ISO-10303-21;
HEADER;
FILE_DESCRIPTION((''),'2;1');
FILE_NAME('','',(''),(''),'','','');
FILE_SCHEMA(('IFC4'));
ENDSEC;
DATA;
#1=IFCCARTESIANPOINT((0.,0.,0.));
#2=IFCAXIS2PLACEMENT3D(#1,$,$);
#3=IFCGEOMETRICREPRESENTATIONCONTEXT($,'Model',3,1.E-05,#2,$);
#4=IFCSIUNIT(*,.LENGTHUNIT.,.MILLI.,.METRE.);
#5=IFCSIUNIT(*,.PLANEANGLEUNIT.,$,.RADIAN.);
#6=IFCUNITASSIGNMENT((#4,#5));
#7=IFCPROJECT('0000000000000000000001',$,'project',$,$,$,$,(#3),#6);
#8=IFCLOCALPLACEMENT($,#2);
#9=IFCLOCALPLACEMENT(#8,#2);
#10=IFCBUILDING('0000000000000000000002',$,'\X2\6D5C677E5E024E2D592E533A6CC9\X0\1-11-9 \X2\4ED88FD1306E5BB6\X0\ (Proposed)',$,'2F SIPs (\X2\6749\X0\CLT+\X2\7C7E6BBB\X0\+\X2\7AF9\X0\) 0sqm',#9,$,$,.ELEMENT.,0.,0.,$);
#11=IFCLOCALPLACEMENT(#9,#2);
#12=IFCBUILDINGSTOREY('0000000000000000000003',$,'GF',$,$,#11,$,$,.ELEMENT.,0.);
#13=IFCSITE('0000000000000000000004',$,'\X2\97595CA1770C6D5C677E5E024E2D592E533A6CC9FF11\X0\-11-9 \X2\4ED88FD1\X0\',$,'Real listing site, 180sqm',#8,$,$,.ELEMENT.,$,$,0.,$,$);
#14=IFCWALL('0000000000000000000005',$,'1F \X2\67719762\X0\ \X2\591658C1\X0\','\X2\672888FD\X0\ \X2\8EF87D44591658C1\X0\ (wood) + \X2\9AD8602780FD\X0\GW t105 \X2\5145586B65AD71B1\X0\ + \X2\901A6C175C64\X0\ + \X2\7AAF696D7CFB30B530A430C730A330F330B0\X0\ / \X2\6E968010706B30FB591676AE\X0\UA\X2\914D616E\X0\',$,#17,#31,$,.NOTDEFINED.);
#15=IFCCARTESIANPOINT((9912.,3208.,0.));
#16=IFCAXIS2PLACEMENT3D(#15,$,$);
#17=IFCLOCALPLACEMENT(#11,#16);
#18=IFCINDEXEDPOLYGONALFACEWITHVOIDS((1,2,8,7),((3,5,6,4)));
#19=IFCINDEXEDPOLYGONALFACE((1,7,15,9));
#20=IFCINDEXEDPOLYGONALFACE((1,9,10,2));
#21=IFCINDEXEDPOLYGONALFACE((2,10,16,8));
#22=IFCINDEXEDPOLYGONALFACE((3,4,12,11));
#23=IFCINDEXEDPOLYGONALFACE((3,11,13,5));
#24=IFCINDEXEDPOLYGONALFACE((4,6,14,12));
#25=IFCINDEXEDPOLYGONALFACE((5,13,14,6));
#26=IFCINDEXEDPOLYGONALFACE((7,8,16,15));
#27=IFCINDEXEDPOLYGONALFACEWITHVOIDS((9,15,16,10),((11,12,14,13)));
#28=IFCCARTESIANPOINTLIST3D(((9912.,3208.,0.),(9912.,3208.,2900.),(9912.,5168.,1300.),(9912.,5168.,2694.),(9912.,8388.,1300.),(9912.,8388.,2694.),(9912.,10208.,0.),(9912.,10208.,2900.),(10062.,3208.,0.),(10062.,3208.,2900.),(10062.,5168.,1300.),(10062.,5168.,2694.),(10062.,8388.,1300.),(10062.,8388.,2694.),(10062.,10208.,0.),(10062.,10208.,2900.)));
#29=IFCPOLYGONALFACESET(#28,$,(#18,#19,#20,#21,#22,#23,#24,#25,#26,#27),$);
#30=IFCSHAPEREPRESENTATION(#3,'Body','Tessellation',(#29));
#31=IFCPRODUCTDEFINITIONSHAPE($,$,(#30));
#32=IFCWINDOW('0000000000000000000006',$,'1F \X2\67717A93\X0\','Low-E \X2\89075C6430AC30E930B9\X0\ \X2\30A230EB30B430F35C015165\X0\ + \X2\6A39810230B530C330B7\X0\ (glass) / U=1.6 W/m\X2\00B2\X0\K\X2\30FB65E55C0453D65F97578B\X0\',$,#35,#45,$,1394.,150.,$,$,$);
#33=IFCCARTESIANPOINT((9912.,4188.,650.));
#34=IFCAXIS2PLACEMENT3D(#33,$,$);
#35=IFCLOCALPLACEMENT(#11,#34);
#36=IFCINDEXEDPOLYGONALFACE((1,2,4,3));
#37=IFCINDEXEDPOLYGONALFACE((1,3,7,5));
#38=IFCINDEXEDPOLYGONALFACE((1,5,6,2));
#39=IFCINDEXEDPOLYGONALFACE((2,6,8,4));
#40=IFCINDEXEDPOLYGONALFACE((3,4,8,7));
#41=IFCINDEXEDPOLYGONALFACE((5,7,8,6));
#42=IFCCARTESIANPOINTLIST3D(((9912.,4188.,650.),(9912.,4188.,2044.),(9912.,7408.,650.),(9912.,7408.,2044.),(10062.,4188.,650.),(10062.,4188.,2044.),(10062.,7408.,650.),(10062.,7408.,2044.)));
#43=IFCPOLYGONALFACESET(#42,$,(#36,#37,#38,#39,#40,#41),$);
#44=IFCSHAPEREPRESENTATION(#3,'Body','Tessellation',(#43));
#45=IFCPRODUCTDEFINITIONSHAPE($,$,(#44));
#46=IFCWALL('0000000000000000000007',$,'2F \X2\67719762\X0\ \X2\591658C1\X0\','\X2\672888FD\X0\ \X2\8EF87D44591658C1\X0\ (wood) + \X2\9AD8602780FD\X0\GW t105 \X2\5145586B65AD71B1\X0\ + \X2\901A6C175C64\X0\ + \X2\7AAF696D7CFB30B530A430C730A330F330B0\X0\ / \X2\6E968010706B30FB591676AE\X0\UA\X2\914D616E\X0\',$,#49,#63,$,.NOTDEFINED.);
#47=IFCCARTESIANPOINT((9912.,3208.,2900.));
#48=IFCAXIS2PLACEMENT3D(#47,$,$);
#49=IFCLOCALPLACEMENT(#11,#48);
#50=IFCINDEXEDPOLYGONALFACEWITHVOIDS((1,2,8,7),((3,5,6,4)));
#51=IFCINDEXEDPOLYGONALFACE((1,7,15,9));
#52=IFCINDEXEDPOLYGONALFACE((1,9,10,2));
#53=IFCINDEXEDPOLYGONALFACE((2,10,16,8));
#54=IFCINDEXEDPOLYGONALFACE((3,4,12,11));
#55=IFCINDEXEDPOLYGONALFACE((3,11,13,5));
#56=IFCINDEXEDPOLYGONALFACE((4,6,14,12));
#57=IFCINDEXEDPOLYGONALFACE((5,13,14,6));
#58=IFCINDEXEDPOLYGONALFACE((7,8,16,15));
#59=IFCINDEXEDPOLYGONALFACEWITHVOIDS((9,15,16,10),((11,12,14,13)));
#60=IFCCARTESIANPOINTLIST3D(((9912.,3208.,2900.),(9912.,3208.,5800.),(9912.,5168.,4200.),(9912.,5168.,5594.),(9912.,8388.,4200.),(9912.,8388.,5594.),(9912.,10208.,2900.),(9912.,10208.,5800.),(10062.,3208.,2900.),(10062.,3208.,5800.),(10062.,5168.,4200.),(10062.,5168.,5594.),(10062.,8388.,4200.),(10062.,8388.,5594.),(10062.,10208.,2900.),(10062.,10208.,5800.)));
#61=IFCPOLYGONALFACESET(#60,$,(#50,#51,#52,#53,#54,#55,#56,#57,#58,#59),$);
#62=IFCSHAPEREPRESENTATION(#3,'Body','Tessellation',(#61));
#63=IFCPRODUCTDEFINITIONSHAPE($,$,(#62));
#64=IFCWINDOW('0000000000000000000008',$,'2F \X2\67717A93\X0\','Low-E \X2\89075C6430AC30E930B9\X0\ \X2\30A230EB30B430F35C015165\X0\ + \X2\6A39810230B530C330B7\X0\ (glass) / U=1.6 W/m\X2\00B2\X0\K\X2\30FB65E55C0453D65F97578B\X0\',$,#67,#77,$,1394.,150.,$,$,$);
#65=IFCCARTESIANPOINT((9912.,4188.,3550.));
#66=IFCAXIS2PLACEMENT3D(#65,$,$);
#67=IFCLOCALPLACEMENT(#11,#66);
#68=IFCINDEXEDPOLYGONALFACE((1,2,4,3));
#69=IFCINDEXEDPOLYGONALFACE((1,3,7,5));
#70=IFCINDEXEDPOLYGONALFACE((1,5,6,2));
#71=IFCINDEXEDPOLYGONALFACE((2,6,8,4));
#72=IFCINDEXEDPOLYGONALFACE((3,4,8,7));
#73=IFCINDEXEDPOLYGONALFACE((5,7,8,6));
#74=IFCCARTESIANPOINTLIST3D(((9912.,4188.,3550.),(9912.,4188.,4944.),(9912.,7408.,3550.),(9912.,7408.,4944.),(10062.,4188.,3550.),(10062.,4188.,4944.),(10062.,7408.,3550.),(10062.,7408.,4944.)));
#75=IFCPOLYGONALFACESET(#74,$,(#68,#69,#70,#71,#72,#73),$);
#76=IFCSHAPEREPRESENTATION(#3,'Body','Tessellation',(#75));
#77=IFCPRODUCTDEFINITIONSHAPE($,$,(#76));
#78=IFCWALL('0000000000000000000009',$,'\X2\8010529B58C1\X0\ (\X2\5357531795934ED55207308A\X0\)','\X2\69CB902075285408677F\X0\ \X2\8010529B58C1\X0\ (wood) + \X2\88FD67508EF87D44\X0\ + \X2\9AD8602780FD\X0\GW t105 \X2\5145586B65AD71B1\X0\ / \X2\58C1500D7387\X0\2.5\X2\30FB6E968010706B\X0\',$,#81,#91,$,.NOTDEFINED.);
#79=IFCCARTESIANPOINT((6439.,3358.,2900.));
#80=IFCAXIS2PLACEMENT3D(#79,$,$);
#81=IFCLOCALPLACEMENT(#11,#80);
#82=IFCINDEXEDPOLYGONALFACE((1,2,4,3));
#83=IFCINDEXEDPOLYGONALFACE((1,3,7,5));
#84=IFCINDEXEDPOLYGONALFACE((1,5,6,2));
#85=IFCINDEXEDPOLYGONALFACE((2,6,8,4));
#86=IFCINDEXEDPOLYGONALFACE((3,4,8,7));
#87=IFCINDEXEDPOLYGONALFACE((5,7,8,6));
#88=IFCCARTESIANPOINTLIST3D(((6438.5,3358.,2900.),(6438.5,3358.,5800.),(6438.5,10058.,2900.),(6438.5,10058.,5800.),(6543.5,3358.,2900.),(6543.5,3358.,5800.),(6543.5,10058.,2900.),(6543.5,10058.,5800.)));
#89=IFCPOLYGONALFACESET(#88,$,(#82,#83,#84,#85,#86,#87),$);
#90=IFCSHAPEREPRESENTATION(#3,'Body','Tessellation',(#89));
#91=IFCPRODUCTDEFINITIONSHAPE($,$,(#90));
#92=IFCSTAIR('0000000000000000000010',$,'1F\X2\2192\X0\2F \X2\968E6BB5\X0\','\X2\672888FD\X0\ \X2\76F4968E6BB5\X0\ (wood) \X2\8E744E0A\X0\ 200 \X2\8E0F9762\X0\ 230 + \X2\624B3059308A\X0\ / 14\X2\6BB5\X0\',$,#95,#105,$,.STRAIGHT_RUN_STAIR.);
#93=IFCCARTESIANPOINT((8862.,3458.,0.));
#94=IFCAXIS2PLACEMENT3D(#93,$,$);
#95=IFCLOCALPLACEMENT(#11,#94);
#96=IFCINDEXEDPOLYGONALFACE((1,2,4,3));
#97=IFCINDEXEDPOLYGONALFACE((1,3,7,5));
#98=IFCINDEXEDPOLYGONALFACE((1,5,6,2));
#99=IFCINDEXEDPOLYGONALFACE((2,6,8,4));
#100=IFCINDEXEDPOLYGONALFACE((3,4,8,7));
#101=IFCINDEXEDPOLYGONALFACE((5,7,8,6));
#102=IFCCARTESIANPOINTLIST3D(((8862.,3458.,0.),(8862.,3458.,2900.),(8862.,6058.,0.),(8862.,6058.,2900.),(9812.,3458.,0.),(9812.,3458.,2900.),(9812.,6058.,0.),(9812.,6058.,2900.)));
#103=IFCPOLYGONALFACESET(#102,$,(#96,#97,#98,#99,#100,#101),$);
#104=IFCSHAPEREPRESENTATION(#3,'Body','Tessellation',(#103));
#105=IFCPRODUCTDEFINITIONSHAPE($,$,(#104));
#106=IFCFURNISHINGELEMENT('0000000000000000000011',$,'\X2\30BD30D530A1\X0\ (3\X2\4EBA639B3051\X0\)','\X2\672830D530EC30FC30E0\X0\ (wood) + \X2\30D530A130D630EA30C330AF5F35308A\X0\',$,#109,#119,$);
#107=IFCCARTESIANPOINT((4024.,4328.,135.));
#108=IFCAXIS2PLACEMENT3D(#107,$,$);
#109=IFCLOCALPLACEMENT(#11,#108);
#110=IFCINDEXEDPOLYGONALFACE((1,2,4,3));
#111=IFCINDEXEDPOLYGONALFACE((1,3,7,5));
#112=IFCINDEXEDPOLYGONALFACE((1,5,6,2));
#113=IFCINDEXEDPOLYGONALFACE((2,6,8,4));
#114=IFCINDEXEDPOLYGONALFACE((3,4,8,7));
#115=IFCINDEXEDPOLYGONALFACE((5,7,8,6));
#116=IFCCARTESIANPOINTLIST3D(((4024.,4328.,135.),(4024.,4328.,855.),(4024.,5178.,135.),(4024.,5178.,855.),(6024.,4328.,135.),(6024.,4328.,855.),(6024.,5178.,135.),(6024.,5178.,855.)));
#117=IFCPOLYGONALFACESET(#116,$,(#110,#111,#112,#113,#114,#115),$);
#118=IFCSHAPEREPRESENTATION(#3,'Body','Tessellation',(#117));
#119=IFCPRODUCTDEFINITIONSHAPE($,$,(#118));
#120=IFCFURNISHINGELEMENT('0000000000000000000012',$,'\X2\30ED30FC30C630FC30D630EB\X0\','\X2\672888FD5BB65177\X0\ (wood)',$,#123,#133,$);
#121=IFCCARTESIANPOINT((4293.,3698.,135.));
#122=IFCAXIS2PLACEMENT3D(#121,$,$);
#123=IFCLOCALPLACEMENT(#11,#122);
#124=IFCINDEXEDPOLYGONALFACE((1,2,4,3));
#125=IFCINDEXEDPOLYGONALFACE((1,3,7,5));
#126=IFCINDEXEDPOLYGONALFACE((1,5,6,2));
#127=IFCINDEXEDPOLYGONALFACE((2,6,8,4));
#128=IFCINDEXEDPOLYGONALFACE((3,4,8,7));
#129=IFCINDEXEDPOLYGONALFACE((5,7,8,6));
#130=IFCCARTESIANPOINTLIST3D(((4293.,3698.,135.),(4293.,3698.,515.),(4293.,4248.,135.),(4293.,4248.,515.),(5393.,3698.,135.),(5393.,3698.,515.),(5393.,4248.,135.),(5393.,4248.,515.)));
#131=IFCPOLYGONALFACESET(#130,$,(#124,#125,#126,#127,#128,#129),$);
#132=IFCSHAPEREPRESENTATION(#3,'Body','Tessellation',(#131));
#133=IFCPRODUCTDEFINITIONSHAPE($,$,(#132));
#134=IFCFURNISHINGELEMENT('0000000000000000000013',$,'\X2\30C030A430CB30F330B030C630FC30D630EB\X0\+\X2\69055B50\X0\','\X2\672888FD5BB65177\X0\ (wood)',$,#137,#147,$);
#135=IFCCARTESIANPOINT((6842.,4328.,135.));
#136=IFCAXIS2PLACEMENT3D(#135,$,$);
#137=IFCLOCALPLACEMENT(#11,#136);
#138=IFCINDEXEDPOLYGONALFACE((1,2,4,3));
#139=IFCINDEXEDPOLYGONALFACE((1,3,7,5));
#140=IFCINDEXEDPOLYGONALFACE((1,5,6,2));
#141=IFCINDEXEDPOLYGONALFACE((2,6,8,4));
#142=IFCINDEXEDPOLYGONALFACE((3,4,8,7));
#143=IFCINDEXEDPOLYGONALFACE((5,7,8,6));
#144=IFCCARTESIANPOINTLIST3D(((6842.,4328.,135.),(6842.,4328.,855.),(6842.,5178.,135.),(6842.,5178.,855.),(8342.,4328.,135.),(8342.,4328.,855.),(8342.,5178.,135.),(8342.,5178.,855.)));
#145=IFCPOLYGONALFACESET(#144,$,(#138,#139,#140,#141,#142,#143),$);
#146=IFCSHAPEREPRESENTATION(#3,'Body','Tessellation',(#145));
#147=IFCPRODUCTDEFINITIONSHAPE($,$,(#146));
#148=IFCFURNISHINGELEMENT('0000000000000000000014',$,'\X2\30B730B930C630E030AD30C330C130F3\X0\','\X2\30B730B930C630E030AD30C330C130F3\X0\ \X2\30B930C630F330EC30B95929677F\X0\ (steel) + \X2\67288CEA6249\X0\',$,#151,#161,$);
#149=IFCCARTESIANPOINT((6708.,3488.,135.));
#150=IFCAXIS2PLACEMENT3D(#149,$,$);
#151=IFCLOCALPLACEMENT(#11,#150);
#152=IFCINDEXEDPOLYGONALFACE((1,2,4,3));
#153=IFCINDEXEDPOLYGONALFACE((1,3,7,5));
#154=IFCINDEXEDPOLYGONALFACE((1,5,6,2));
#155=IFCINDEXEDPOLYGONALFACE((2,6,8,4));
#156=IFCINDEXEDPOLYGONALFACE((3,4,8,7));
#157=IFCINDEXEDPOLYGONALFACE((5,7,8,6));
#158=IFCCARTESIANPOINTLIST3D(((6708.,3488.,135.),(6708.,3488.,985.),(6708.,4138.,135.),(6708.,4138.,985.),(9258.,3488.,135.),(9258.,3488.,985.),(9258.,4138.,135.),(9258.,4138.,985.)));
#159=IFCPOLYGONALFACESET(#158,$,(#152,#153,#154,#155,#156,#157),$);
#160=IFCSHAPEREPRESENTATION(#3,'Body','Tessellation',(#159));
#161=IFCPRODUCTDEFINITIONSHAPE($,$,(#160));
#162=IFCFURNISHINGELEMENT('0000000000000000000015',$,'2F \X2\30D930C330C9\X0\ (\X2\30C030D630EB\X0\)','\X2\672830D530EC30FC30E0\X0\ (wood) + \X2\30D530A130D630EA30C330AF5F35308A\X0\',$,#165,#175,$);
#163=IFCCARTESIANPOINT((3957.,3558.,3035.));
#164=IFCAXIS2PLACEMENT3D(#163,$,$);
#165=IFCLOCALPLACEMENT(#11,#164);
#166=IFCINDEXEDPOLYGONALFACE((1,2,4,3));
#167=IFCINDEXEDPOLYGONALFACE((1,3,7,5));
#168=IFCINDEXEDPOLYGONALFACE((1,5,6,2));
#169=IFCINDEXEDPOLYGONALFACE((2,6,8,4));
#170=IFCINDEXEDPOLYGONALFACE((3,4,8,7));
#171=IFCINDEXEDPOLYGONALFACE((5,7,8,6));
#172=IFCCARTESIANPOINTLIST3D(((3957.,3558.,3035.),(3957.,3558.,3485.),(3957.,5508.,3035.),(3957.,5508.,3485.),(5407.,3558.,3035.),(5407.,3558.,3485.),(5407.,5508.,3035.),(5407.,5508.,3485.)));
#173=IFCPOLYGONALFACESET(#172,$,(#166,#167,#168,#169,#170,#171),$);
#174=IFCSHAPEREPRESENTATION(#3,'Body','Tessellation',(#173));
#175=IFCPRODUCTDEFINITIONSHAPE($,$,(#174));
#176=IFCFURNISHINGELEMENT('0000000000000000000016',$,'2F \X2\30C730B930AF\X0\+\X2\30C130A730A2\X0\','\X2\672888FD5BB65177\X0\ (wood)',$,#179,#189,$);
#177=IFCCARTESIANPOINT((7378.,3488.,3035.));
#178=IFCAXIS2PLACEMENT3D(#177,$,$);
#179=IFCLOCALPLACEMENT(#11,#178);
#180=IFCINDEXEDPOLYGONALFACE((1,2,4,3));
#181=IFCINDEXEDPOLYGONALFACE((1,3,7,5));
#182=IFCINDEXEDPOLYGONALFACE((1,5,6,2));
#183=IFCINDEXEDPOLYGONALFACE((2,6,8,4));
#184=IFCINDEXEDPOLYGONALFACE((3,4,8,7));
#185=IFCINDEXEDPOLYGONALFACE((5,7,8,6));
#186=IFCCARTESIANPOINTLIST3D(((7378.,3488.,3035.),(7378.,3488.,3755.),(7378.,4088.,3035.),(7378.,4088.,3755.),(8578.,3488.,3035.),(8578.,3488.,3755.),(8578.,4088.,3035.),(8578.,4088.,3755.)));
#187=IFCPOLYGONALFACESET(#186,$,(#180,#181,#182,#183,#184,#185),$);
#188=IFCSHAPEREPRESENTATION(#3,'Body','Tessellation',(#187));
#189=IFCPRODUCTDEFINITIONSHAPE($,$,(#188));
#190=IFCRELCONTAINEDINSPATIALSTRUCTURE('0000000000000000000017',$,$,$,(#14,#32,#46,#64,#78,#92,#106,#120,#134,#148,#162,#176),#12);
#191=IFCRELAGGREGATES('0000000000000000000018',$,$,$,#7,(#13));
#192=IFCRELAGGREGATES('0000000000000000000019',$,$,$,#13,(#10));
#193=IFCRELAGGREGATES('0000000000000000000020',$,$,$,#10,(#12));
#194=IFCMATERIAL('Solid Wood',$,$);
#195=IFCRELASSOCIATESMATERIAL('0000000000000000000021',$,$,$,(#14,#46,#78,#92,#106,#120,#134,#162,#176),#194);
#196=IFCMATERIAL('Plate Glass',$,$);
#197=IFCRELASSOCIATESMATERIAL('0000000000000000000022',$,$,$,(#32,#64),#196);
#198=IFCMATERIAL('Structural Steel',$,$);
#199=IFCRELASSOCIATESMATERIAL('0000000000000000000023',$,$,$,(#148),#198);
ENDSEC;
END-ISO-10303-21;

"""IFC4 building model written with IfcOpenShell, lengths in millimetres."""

from ifc_helpers import new_model, si_unit, frame, frame_2d, origin, place, context, project, spatial, rectangle, extrude, material, element, fill, save


model = new_model("IFC4")

# Units and contexts
model_context = context("Model", 3, precision=1e-05, world=origin())
ifc_project = project(units=[si_unit("LENGTHUNIT", "METRE", prefix="MILLI"), si_unit("PLANEANGLEUNIT", "RADIAN")], contexts=[model_context])

# Site, building, storey
site_placement = place(None, origin())
site = spatial("IfcSite", under=ifc_project, at=site_placement, Name="静岡県浜松市中央区泉１-11-9 付近", ObjectType="Real listing site, 180sqm", CompositionType="ELEMENT", RefElevation=0.0)
building_placement = place(site_placement, origin())
building = spatial("IfcBuilding", under=site, at=building_placement, Name="浜松市中央区泉1-11-9 付近の家 (Proposed)", ObjectType="2F SIPs (杉CLT+籾殻+竹) 0sqm", CompositionType="ELEMENT", ElevationOfRefHeight=0.0, ElevationOfTerrain=0.0)
storey_placement = place(building_placement, origin())
storey = spatial("IfcBuildingStorey", under=building, at=storey_placement, Name="GF", CompositionType="ELEMENT", Elevation=0.0)

# Wall, opening, window
ifc_material_1 = material(Name="Solid Wood")
wall_1_placement = place(storey_placement, frame((9912.0, 3208.0, 0.0)))
wall_1 = element("IfcWall", 1, at=wall_1_placement, inside=storey, material=ifc_material_1, Name="1F 東面 外壁", Description="木製 軸組外壁 (wood) + 高性能GW t105 充填断熱 + 通気層 + 窯業系サイディング / 準耐火・外皮UA配慮", PredefinedType="NOTDEFINED", context=model_context, shape_type="SweptSolid", body=[
    extrude(rectangle(XDim=150.0, YDim=7000.0, at=frame_2d((75.0, 3500.0))), frame((9912.0, 3208.0, 0.0)), (0.0, 0.0, 1.0), 2900.0),
])
opening_1_placement = place(storey_placement, frame((9912.0, 4188.0, 650.0)))
opening_1 = element("IfcOpeningElement", 2, at=opening_1_placement, cuts=wall_1, PredefinedType="NOTDEFINED", context=model_context, shape_type="SweptSolid", body=[
    extrude(rectangle(XDim=150.0, YDim=3220.0, at=frame_2d((75.0, 1610.0))), frame((9912.0, 4188.0, 650.0)), (0.0, 0.0, 1.0), 1394.0),
])
ifc_material_2 = material(Name="Plate Glass")
window_1_placement = place(storey_placement, frame((9912.0, 4188.0, 650.0)))
window_1 = element("IfcWindow", 3, at=window_1_placement, inside=storey, material=ifc_material_2, Name="1F 東窓", Description="Low-E 複層ガラス アルゴン封入 + 樹脂サッシ (glass) / U=1.6 W/m²K・日射取得型", OverallHeight=1394.0, OverallWidth=150.0, context=model_context, shape_type="SweptSolid", body=[
    extrude(rectangle(XDim=150.0, YDim=3220.0, at=frame_2d((75.0, 1610.0))), frame((9912.0, 4188.0, 650.0)), (0.0, 0.0, 1.0), 1394.0),
])
fill(opening_1, window_1)

# Wall, opening, window
wall_2_placement = place(storey_placement, frame((9912.0, 3208.0, 2900.0)))
wall_2 = element("IfcWall", 4, at=wall_2_placement, inside=storey, material=ifc_material_1, Name="2F 東面 外壁", Description="木製 軸組外壁 (wood) + 高性能GW t105 充填断熱 + 通気層 + 窯業系サイディング / 準耐火・外皮UA配慮", PredefinedType="NOTDEFINED", context=model_context, shape_type="SweptSolid", body=[
    extrude(rectangle(XDim=150.0, YDim=7000.0, at=frame_2d((75.0, 3500.0))), frame((9912.0, 3208.0, 2900.0)), (0.0, 0.0, 1.0), 2900.0),
])
opening_2_placement = place(storey_placement, frame((9912.0, 4188.0, 3550.0)))
opening_2 = element("IfcOpeningElement", 5, at=opening_2_placement, cuts=wall_2, PredefinedType="NOTDEFINED", context=model_context, shape_type="SweptSolid", body=[
    extrude(rectangle(XDim=150.0, YDim=3220.0, at=frame_2d((75.0, 1610.0))), frame((9912.0, 4188.0, 3550.0)), (0.0, 0.0, 1.0), 1394.0),
])
window_2_placement = place(storey_placement, frame((9912.0, 4188.0, 3550.0)))
window_2 = element("IfcWindow", 6, at=window_2_placement, inside=storey, material=ifc_material_2, Name="2F 東窓", Description="Low-E 複層ガラス アルゴン封入 + 樹脂サッシ (glass) / U=1.6 W/m²K・日射取得型", OverallHeight=1394.0, OverallWidth=150.0, context=model_context, shape_type="SweptSolid", body=[
    extrude(rectangle(XDim=150.0, YDim=3220.0, at=frame_2d((75.0, 1610.0))), frame((9912.0, 4188.0, 3550.0)), (0.0, 0.0, 1.0), 1394.0),
])
fill(opening_2, window_2)

# Wall
wall_3_placement = place(storey_placement, frame((6439.0, 3358.0, 2900.0)))
element("IfcWall", 7, at=wall_3_placement, inside=storey, material=ifc_material_1, Name="耐力壁 (南北間仕切り)", Description="構造用合板 耐力壁 (wood) + 製材軸組 + 高性能GW t105 充填断熱 / 壁倍率2.5・準耐火", PredefinedType="NOTDEFINED", context=model_context, shape_type="SweptSolid", body=[
    extrude(rectangle(XDim=105.0, YDim=6700.0, at=frame_2d((52.0, 3350.0))), frame((6439.0, 3358.0, 2900.0)), (0.0, 0.0, 1.0), 2900.0),
])

# Stair
stair_placement = place(storey_placement, frame((8862.0, 3458.0, 0.0)))
element("IfcStair", 8, at=stair_placement, inside=storey, material=ifc_material_1, Name="1F→2F 階段", Description="木製 直階段 (wood) 蹴上 200 踏面 230 + 手すり / 14段", PredefinedType="STRAIGHT_RUN_STAIR", context=model_context, shape_type="SweptSolid", body=[
    extrude(rectangle(XDim=950.0, YDim=2600.0, at=frame_2d((475.0, 1300.0))), frame((8862.0, 3458.0, 0.0)), (0.0, 0.0, 1.0), 2900.0),
])

# Furnishing elements
furnishing_1_placement = place(storey_placement, frame((4024.0, 4328.0, 135.0)))
element("IfcFurnishingElement", 9, at=furnishing_1_placement, inside=storey, material=ifc_material_1, Name="ソファ (3人掛け)", Description="木フレーム (wood) + ファブリック張り", context=model_context, shape_type="SweptSolid", body=[
    extrude(rectangle(XDim=2000.0, YDim=850.0, at=frame_2d((1000.0, 425.0))), frame((4024.0, 4328.0, 135.0)), (0.0, 0.0, 1.0), 720.0),
])
furnishing_2_placement = place(storey_placement, frame((4293.0, 3698.0, 135.0)))
element("IfcFurnishingElement", 10, at=furnishing_2_placement, inside=storey, material=ifc_material_1, Name="ローテーブル", Description="木製家具 (wood)", context=model_context, shape_type="SweptSolid", body=[
    extrude(rectangle(XDim=1100.0, YDim=550.0, at=frame_2d((550.0, 275.0))), frame((4293.0, 3698.0, 135.0)), (0.0, 0.0, 1.0), 380.0),
])
furnishing_3_placement = place(storey_placement, frame((6842.0, 4328.0, 135.0)))
element("IfcFurnishingElement", 11, at=furnishing_3_placement, inside=storey, material=ifc_material_1, Name="ダイニングテーブル+椅子", Description="木製家具 (wood)", context=model_context, shape_type="SweptSolid", body=[
    extrude(rectangle(XDim=1500.0, YDim=850.0, at=frame_2d((750.0, 425.0))), frame((6842.0, 4328.0, 135.0)), (0.0, 0.0, 1.0), 720.0),
])
ifc_material_3 = material(Name="Structural Steel")
furnishing_4_placement = place(storey_placement, frame((6708.0, 3488.0, 135.0)))
element("IfcFurnishingElement", 12, at=furnishing_4_placement, inside=storey, material=ifc_material_3, Name="システムキッチン", Description="システムキッチン ステンレス天板 (steel) + 木質扉", context=model_context, shape_type="SweptSolid", body=[
    extrude(rectangle(XDim=2550.0, YDim=650.0, at=frame_2d((1275.0, 325.0))), frame((6708.0, 3488.0, 135.0)), (0.0, 0.0, 1.0), 850.0),
])
furnishing_5_placement = place(storey_placement, frame((3957.0, 3558.0, 3035.0)))
element("IfcFurnishingElement", 13, at=furnishing_5_placement, inside=storey, material=ifc_material_1, Name="2F ベッド (ダブル)", Description="木フレーム (wood) + ファブリック張り", context=model_context, shape_type="SweptSolid", body=[
    extrude(rectangle(XDim=1450.0, YDim=1950.0, at=frame_2d((725.0, 975.0))), frame((3957.0, 3558.0, 3035.0)), (0.0, 0.0, 1.0), 450.0),
])
furnishing_6_placement = place(storey_placement, frame((7378.0, 3488.0, 3035.0)))
element("IfcFurnishingElement", 14, at=furnishing_6_placement, inside=storey, material=ifc_material_1, Name="2F デスク+チェア", Description="木製家具 (wood)", context=model_context, shape_type="SweptSolid", body=[
    extrude(rectangle(XDim=1200.0, YDim=600.0, at=frame_2d((600.0, 300.0))), frame((7378.0, 3488.0, 3035.0)), (0.0, 0.0, 1.0), 720.0),
])

save(model, "model.ifc")
